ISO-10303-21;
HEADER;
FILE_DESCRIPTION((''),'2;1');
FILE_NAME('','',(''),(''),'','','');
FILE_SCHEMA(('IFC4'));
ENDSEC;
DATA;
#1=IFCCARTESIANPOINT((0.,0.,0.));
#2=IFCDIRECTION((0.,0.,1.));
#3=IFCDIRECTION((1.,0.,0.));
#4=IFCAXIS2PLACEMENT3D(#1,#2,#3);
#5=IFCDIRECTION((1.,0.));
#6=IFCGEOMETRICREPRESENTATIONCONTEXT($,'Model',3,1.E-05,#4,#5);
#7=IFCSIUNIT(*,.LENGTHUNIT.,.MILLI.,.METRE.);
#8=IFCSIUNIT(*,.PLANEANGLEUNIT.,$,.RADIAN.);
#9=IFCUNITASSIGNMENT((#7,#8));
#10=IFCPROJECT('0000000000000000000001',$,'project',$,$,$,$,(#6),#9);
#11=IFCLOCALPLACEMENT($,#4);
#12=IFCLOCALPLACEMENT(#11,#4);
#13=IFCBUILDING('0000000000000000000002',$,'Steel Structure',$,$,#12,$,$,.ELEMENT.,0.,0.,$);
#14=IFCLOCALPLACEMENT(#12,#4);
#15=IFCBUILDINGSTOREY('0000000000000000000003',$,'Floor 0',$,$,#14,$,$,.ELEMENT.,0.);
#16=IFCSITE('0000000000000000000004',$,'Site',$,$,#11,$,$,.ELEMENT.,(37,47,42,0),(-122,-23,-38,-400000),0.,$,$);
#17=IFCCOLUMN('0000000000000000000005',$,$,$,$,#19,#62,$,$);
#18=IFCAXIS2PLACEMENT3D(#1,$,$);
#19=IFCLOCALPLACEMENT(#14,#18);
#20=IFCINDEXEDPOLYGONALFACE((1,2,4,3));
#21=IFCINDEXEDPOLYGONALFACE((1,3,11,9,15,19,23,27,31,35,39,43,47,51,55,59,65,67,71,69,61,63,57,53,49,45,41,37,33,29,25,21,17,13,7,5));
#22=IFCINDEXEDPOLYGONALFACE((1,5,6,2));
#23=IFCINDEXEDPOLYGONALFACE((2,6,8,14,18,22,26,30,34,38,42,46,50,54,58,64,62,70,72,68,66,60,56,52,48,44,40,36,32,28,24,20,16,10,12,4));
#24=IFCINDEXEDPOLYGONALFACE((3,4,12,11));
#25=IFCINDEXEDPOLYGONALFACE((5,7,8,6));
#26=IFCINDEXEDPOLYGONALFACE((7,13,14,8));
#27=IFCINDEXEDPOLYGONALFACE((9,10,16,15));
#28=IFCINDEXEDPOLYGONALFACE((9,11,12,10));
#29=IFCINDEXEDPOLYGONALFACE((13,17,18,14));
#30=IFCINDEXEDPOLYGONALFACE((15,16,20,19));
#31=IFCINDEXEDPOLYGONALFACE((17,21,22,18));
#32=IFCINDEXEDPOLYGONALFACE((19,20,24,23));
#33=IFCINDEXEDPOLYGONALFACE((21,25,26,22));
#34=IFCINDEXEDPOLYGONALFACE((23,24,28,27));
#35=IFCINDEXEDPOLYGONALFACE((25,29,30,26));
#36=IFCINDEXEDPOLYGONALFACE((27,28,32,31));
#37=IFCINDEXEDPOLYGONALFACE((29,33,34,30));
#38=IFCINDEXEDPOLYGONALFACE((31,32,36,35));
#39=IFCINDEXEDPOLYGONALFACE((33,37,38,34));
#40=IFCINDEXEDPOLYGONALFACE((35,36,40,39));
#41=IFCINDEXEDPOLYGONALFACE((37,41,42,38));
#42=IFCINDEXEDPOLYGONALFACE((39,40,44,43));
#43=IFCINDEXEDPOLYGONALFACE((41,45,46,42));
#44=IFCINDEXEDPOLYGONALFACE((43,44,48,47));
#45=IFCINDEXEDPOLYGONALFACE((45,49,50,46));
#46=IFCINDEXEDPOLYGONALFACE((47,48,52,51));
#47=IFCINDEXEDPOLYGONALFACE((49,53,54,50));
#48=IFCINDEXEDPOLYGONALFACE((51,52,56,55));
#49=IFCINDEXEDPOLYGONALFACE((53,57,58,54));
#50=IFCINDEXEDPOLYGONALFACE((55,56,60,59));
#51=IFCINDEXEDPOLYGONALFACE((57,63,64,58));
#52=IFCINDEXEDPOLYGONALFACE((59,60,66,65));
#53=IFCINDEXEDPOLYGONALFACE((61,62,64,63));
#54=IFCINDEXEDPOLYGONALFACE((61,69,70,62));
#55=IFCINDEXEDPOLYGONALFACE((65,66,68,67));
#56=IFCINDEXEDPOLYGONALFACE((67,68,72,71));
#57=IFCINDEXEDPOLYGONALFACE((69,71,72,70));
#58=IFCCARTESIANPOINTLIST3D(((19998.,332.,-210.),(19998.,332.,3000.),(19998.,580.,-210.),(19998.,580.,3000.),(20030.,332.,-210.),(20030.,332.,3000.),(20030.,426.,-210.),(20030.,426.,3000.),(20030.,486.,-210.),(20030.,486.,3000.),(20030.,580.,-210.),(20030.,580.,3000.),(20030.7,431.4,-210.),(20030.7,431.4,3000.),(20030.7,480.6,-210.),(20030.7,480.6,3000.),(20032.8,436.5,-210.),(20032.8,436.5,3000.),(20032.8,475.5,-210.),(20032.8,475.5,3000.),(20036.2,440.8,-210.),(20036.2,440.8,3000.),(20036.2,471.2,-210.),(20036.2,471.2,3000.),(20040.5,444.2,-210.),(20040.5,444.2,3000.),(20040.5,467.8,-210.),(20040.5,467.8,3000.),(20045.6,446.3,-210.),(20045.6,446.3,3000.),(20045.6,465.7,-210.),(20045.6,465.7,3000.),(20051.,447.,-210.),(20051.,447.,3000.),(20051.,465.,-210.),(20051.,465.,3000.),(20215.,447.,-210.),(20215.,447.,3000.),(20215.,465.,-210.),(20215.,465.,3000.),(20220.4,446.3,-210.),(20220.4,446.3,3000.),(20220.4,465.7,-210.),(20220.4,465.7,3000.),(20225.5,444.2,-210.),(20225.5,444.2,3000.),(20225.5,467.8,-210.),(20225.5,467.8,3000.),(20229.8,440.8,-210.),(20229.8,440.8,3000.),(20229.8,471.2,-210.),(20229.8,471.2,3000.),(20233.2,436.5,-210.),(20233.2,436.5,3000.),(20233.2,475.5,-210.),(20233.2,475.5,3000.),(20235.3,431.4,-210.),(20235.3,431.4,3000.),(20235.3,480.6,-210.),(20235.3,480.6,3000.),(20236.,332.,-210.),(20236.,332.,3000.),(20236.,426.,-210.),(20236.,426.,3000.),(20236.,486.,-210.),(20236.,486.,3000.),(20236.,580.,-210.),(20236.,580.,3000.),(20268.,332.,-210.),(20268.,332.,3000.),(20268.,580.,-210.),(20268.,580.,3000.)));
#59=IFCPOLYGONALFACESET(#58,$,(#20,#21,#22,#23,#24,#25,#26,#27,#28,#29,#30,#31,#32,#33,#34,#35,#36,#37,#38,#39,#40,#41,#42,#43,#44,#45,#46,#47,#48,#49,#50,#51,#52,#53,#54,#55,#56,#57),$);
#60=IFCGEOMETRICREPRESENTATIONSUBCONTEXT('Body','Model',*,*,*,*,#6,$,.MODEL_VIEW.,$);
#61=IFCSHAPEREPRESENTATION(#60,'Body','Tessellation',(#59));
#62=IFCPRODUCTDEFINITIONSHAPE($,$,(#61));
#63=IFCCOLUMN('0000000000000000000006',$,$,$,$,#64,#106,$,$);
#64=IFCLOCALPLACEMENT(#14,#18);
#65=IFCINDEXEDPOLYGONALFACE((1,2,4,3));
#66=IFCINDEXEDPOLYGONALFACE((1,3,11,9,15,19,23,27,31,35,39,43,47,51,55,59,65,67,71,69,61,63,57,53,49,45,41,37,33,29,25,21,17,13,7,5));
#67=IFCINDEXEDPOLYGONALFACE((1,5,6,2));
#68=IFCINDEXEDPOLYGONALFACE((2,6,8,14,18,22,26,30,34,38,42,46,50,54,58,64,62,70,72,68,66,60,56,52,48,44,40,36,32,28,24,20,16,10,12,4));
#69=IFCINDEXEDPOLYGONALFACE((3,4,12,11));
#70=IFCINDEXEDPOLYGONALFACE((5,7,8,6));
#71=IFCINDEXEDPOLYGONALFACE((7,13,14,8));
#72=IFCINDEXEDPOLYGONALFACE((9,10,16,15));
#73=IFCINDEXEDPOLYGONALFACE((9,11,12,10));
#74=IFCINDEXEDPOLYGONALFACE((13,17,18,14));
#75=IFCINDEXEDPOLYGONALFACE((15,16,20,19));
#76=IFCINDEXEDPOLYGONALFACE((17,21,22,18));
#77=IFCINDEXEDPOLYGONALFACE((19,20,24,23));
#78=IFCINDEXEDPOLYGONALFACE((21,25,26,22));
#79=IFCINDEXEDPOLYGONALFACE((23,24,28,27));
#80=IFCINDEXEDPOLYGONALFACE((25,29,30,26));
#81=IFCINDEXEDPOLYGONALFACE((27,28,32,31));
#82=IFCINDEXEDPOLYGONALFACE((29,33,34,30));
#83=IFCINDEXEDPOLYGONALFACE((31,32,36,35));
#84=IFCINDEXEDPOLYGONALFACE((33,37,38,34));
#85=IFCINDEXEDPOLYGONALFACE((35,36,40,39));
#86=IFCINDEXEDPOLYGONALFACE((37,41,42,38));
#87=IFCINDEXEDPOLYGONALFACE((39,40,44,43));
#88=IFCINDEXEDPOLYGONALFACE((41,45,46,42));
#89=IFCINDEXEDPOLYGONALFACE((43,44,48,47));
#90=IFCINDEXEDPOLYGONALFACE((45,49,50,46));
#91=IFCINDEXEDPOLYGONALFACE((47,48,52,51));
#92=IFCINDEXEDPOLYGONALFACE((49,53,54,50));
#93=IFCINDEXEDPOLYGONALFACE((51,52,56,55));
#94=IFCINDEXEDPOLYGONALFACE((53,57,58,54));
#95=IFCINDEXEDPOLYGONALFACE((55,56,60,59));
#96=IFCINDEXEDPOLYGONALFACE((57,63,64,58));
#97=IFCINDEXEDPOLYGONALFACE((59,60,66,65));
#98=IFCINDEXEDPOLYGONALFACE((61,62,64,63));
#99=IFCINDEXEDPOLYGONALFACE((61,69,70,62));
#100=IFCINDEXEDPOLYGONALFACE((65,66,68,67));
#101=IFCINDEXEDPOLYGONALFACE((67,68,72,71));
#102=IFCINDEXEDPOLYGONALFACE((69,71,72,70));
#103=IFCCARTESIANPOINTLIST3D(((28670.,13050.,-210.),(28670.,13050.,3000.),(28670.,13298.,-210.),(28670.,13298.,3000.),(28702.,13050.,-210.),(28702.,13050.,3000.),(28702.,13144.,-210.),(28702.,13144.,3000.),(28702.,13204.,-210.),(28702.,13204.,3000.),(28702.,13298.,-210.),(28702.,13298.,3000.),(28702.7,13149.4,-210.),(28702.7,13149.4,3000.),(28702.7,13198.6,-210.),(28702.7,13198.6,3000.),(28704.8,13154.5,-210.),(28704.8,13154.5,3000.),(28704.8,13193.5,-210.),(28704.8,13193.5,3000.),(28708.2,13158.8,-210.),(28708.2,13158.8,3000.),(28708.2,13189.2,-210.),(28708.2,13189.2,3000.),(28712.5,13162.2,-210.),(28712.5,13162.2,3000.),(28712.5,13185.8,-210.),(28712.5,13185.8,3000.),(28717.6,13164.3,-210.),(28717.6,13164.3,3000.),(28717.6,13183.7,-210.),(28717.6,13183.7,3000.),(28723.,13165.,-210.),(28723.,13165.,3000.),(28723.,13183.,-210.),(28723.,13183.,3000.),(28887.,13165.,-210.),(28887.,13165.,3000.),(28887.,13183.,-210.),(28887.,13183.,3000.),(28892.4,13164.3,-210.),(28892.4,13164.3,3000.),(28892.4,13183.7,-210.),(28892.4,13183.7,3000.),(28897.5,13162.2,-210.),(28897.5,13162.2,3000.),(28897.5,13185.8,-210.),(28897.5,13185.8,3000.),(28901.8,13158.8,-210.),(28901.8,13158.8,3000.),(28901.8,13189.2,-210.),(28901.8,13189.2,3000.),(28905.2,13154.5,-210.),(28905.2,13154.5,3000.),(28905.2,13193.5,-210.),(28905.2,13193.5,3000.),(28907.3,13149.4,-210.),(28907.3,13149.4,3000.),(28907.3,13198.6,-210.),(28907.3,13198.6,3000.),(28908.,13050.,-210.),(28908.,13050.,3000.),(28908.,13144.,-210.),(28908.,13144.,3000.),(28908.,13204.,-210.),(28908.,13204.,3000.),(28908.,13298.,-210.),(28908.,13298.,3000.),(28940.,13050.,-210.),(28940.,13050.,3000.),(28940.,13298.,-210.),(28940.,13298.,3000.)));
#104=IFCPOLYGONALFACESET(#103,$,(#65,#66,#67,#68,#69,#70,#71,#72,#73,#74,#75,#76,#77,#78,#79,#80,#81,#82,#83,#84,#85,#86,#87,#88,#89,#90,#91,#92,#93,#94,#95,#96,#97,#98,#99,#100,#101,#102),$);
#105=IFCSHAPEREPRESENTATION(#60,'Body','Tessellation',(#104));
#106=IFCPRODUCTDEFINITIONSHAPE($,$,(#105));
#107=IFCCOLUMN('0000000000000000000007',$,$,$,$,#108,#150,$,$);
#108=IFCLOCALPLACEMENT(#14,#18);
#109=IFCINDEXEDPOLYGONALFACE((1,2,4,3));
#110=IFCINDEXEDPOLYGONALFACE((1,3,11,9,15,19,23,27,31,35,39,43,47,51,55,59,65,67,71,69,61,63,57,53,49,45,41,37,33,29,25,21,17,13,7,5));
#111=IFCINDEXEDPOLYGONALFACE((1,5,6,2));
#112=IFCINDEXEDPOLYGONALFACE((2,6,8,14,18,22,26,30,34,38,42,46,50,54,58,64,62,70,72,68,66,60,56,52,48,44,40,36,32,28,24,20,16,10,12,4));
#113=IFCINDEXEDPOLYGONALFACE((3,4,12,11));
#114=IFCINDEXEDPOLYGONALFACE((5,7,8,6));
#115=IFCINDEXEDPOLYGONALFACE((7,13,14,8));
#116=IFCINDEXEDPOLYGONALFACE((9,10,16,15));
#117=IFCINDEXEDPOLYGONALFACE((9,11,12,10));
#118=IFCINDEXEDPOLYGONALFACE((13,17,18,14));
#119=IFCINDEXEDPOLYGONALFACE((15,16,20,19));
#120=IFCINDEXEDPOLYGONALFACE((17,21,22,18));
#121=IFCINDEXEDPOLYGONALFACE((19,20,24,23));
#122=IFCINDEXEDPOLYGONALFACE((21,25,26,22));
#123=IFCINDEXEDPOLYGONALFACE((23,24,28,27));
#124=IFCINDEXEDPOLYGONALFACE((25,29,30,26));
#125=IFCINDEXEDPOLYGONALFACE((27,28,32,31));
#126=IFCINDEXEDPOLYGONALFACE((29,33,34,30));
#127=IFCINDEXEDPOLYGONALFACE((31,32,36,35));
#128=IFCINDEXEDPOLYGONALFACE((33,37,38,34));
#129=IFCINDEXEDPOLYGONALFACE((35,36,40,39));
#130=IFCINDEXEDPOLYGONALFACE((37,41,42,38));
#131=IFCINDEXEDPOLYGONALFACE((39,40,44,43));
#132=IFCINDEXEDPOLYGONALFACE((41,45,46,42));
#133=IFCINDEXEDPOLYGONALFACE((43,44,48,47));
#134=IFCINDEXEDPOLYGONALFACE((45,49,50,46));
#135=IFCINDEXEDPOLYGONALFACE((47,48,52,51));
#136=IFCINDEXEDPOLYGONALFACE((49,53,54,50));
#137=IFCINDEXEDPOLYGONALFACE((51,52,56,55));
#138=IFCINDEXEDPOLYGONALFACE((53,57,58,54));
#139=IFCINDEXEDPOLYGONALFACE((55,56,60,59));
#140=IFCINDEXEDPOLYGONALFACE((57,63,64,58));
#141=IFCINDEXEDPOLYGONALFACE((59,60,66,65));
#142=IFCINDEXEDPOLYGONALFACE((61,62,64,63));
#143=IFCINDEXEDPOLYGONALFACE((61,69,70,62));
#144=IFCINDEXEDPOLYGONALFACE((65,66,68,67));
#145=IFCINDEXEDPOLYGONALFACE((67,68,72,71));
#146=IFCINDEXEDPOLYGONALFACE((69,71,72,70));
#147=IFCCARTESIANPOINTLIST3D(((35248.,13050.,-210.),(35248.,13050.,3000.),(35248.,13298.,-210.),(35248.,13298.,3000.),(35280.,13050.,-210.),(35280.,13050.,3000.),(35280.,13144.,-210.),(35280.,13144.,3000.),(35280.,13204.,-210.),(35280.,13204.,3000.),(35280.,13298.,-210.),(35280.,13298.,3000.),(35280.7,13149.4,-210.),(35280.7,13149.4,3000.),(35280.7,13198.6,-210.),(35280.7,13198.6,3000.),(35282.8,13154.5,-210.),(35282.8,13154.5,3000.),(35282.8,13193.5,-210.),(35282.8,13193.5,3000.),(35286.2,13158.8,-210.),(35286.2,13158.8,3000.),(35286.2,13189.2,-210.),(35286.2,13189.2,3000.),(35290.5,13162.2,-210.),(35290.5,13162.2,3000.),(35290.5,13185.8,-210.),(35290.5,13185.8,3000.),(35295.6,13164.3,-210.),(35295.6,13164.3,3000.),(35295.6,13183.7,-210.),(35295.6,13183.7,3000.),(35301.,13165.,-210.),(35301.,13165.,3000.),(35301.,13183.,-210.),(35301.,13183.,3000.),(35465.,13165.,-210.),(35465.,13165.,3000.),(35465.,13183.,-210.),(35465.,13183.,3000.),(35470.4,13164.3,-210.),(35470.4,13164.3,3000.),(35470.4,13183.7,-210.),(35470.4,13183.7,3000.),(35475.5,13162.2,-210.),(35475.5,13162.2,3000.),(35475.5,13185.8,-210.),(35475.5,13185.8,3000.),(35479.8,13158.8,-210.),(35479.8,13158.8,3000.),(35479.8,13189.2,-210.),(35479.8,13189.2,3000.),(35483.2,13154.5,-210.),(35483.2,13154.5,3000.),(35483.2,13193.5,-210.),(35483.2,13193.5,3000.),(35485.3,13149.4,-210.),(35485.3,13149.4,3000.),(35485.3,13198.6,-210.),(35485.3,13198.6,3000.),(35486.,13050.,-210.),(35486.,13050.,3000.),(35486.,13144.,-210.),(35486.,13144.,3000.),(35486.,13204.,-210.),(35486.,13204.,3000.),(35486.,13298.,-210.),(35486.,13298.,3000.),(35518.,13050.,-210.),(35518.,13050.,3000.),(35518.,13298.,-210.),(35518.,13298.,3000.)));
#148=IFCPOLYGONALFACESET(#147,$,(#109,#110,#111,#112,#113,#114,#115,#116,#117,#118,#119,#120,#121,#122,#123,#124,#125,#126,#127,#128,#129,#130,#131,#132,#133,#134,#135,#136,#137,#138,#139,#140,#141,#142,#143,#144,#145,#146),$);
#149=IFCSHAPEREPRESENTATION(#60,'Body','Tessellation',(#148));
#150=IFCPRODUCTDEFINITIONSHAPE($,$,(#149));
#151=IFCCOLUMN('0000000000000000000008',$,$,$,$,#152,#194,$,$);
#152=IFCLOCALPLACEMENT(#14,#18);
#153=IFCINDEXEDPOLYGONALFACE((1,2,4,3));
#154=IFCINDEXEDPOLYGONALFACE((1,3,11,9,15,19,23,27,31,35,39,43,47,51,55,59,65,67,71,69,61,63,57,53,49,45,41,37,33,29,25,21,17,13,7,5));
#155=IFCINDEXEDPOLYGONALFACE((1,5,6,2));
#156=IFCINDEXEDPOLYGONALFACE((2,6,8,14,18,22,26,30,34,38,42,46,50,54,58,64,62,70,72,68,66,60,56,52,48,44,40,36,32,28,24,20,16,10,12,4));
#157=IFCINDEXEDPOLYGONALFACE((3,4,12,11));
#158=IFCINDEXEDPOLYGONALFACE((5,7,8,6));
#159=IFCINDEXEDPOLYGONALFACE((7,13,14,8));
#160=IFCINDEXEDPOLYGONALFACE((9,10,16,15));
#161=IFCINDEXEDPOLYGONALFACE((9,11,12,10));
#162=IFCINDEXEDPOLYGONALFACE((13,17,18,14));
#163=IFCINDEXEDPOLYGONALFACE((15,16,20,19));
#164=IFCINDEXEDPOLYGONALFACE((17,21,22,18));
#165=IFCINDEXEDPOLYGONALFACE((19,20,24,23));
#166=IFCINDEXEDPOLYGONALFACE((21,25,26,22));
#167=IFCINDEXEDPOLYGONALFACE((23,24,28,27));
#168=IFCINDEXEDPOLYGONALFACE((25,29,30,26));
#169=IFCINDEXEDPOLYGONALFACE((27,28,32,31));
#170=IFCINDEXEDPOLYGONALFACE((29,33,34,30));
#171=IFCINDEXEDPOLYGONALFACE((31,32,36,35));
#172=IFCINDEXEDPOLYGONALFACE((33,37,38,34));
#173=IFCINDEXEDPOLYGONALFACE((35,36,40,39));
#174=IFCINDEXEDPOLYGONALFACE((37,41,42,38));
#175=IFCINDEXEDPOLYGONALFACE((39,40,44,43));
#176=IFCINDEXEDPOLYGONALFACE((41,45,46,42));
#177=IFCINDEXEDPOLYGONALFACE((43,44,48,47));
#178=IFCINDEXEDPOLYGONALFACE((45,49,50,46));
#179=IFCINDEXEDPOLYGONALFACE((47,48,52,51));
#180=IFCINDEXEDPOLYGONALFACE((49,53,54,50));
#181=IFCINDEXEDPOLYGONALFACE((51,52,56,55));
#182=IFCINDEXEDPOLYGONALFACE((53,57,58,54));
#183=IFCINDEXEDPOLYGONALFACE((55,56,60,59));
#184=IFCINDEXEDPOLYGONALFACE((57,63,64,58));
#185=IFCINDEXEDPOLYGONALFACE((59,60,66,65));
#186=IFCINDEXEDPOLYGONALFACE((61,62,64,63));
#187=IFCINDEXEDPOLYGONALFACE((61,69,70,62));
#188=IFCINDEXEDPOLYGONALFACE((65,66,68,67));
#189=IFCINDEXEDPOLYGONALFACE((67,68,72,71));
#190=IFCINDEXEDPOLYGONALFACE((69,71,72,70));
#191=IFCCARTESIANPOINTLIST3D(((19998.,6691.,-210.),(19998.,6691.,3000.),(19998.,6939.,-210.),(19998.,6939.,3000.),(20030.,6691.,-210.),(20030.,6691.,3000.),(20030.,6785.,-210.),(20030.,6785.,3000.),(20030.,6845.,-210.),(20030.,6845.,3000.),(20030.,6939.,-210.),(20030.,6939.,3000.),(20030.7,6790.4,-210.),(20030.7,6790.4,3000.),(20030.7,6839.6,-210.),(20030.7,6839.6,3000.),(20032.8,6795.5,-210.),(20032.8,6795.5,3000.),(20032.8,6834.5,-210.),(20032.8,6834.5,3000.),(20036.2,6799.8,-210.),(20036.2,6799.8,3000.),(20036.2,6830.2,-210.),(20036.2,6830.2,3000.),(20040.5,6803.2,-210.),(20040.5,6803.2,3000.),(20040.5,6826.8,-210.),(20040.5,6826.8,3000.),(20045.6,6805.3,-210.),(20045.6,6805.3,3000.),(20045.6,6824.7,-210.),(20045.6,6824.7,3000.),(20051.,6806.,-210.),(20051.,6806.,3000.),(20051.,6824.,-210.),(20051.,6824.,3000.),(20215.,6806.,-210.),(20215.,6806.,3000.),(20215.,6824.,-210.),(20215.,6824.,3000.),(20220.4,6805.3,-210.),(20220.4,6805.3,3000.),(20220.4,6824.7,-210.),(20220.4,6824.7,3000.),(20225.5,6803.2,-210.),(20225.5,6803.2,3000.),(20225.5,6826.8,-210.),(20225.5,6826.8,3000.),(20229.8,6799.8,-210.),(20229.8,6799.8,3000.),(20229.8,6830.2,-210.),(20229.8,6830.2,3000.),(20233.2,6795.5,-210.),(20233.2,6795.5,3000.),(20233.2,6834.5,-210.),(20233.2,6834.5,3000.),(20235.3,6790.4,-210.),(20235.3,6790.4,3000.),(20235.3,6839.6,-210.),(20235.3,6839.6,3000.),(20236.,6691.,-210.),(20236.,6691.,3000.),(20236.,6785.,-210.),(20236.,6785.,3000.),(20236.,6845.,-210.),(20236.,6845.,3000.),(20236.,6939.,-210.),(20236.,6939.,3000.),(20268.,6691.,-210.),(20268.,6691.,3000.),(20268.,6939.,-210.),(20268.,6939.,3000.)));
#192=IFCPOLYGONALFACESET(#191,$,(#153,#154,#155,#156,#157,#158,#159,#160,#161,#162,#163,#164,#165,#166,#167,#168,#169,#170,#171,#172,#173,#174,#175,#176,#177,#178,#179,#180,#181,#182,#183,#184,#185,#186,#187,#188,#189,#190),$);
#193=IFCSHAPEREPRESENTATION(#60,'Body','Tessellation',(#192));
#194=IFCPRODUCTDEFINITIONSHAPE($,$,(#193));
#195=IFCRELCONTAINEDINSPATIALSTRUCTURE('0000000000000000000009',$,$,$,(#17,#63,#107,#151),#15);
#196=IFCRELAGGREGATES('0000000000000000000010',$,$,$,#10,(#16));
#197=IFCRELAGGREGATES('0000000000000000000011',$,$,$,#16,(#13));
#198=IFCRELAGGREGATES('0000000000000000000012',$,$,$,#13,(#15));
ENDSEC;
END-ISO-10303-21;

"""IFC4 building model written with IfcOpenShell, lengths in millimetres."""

from ifc_helpers import new_model, si_unit, direction, frame, origin_with_axes, origin_2d_with_axis, place, context, subcontext, project, spatial, i_section, extrude, element, save


model = new_model("IFC4")

# Units and contexts
model_context = context("Model", 3, precision=1e-05, world=origin_with_axes(), true_north=direction((1.0, 0.0)))
body_context = subcontext(model_context, "Body", "Model", "MODEL_VIEW")
ifc_project = project(units=[si_unit("LENGTHUNIT", "METRE", prefix="MILLI"), si_unit("PLANEANGLEUNIT", "RADIAN")], contexts=[model_context])

# Site, building, storey
site_placement = place(None, origin_with_axes())
site = spatial("IfcSite", under=ifc_project, at=site_placement, Name="Site", CompositionType="ELEMENT", RefLatitude=(37, 47, 42, 0), RefLongitude=(-122, -23, -38, -400000), RefElevation=0.0)
building_placement = place(site_placement, origin_with_axes())
building = spatial("IfcBuilding", under=site, at=building_placement, Name="Steel Structure", CompositionType="ELEMENT", ElevationOfRefHeight=0.0, ElevationOfTerrain=0.0)
storey_placement = place(building_placement, origin_with_axes())
storey = spatial("IfcBuildingStorey", under=building, at=storey_placement, Name="Floor 0", CompositionType="ELEMENT", Elevation=0.0)

# Columns
for number, where, z_axis, x_axis in (
    (1, (20133.0, 456.0, -210.0), (0.0, 0.0, 1.0), (0.0, 1.0, 0.0)),
    (2, (28805.0, 13174.0, -210.0), (0.0, 0.0, 1.0), (0.0, 1.0, 0.0)),
    (3, (35383.0, 13174.0, -210.0), (0.0, 0.0, 1.0), (0.0, 1.0, 0.0)),
):
    element("IfcColumn", number, at=place(storey_placement, frame(where, z_axis=z_axis, x_axis=x_axis)), inside=storey, context=body_context, shape_type="SweptSolid", body=[
        extrude(i_section(OverallWidth=248.0, OverallDepth=270.0, WebThickness=18.0, FlangeThickness=32.0, FilletRadius=21.0, at=origin_2d_with_axis()), origin_with_axes(), (0.0, 0.0, 1.0), 3210.0),
    ])
column_1_placement = place(storey_placement, frame((20133.0, 6815.0, -210.0), z_axis=(0.0, 0.0, 1.0), x_axis=(0.0, -1.0, 0.0)))
element("IfcColumn", 4, at=column_1_placement, inside=storey, context=body_context, shape_type="SweptSolid", body=[
    extrude(i_section(OverallWidth=248.0, OverallDepth=270.0, WebThickness=18.0, FlangeThickness=32.0, FilletRadius=21.0, at=origin_2d_with_axis()), origin_with_axes(), (0.0, 0.0, 1.0), 3210.0),
])

save(model, "model.ifc")
